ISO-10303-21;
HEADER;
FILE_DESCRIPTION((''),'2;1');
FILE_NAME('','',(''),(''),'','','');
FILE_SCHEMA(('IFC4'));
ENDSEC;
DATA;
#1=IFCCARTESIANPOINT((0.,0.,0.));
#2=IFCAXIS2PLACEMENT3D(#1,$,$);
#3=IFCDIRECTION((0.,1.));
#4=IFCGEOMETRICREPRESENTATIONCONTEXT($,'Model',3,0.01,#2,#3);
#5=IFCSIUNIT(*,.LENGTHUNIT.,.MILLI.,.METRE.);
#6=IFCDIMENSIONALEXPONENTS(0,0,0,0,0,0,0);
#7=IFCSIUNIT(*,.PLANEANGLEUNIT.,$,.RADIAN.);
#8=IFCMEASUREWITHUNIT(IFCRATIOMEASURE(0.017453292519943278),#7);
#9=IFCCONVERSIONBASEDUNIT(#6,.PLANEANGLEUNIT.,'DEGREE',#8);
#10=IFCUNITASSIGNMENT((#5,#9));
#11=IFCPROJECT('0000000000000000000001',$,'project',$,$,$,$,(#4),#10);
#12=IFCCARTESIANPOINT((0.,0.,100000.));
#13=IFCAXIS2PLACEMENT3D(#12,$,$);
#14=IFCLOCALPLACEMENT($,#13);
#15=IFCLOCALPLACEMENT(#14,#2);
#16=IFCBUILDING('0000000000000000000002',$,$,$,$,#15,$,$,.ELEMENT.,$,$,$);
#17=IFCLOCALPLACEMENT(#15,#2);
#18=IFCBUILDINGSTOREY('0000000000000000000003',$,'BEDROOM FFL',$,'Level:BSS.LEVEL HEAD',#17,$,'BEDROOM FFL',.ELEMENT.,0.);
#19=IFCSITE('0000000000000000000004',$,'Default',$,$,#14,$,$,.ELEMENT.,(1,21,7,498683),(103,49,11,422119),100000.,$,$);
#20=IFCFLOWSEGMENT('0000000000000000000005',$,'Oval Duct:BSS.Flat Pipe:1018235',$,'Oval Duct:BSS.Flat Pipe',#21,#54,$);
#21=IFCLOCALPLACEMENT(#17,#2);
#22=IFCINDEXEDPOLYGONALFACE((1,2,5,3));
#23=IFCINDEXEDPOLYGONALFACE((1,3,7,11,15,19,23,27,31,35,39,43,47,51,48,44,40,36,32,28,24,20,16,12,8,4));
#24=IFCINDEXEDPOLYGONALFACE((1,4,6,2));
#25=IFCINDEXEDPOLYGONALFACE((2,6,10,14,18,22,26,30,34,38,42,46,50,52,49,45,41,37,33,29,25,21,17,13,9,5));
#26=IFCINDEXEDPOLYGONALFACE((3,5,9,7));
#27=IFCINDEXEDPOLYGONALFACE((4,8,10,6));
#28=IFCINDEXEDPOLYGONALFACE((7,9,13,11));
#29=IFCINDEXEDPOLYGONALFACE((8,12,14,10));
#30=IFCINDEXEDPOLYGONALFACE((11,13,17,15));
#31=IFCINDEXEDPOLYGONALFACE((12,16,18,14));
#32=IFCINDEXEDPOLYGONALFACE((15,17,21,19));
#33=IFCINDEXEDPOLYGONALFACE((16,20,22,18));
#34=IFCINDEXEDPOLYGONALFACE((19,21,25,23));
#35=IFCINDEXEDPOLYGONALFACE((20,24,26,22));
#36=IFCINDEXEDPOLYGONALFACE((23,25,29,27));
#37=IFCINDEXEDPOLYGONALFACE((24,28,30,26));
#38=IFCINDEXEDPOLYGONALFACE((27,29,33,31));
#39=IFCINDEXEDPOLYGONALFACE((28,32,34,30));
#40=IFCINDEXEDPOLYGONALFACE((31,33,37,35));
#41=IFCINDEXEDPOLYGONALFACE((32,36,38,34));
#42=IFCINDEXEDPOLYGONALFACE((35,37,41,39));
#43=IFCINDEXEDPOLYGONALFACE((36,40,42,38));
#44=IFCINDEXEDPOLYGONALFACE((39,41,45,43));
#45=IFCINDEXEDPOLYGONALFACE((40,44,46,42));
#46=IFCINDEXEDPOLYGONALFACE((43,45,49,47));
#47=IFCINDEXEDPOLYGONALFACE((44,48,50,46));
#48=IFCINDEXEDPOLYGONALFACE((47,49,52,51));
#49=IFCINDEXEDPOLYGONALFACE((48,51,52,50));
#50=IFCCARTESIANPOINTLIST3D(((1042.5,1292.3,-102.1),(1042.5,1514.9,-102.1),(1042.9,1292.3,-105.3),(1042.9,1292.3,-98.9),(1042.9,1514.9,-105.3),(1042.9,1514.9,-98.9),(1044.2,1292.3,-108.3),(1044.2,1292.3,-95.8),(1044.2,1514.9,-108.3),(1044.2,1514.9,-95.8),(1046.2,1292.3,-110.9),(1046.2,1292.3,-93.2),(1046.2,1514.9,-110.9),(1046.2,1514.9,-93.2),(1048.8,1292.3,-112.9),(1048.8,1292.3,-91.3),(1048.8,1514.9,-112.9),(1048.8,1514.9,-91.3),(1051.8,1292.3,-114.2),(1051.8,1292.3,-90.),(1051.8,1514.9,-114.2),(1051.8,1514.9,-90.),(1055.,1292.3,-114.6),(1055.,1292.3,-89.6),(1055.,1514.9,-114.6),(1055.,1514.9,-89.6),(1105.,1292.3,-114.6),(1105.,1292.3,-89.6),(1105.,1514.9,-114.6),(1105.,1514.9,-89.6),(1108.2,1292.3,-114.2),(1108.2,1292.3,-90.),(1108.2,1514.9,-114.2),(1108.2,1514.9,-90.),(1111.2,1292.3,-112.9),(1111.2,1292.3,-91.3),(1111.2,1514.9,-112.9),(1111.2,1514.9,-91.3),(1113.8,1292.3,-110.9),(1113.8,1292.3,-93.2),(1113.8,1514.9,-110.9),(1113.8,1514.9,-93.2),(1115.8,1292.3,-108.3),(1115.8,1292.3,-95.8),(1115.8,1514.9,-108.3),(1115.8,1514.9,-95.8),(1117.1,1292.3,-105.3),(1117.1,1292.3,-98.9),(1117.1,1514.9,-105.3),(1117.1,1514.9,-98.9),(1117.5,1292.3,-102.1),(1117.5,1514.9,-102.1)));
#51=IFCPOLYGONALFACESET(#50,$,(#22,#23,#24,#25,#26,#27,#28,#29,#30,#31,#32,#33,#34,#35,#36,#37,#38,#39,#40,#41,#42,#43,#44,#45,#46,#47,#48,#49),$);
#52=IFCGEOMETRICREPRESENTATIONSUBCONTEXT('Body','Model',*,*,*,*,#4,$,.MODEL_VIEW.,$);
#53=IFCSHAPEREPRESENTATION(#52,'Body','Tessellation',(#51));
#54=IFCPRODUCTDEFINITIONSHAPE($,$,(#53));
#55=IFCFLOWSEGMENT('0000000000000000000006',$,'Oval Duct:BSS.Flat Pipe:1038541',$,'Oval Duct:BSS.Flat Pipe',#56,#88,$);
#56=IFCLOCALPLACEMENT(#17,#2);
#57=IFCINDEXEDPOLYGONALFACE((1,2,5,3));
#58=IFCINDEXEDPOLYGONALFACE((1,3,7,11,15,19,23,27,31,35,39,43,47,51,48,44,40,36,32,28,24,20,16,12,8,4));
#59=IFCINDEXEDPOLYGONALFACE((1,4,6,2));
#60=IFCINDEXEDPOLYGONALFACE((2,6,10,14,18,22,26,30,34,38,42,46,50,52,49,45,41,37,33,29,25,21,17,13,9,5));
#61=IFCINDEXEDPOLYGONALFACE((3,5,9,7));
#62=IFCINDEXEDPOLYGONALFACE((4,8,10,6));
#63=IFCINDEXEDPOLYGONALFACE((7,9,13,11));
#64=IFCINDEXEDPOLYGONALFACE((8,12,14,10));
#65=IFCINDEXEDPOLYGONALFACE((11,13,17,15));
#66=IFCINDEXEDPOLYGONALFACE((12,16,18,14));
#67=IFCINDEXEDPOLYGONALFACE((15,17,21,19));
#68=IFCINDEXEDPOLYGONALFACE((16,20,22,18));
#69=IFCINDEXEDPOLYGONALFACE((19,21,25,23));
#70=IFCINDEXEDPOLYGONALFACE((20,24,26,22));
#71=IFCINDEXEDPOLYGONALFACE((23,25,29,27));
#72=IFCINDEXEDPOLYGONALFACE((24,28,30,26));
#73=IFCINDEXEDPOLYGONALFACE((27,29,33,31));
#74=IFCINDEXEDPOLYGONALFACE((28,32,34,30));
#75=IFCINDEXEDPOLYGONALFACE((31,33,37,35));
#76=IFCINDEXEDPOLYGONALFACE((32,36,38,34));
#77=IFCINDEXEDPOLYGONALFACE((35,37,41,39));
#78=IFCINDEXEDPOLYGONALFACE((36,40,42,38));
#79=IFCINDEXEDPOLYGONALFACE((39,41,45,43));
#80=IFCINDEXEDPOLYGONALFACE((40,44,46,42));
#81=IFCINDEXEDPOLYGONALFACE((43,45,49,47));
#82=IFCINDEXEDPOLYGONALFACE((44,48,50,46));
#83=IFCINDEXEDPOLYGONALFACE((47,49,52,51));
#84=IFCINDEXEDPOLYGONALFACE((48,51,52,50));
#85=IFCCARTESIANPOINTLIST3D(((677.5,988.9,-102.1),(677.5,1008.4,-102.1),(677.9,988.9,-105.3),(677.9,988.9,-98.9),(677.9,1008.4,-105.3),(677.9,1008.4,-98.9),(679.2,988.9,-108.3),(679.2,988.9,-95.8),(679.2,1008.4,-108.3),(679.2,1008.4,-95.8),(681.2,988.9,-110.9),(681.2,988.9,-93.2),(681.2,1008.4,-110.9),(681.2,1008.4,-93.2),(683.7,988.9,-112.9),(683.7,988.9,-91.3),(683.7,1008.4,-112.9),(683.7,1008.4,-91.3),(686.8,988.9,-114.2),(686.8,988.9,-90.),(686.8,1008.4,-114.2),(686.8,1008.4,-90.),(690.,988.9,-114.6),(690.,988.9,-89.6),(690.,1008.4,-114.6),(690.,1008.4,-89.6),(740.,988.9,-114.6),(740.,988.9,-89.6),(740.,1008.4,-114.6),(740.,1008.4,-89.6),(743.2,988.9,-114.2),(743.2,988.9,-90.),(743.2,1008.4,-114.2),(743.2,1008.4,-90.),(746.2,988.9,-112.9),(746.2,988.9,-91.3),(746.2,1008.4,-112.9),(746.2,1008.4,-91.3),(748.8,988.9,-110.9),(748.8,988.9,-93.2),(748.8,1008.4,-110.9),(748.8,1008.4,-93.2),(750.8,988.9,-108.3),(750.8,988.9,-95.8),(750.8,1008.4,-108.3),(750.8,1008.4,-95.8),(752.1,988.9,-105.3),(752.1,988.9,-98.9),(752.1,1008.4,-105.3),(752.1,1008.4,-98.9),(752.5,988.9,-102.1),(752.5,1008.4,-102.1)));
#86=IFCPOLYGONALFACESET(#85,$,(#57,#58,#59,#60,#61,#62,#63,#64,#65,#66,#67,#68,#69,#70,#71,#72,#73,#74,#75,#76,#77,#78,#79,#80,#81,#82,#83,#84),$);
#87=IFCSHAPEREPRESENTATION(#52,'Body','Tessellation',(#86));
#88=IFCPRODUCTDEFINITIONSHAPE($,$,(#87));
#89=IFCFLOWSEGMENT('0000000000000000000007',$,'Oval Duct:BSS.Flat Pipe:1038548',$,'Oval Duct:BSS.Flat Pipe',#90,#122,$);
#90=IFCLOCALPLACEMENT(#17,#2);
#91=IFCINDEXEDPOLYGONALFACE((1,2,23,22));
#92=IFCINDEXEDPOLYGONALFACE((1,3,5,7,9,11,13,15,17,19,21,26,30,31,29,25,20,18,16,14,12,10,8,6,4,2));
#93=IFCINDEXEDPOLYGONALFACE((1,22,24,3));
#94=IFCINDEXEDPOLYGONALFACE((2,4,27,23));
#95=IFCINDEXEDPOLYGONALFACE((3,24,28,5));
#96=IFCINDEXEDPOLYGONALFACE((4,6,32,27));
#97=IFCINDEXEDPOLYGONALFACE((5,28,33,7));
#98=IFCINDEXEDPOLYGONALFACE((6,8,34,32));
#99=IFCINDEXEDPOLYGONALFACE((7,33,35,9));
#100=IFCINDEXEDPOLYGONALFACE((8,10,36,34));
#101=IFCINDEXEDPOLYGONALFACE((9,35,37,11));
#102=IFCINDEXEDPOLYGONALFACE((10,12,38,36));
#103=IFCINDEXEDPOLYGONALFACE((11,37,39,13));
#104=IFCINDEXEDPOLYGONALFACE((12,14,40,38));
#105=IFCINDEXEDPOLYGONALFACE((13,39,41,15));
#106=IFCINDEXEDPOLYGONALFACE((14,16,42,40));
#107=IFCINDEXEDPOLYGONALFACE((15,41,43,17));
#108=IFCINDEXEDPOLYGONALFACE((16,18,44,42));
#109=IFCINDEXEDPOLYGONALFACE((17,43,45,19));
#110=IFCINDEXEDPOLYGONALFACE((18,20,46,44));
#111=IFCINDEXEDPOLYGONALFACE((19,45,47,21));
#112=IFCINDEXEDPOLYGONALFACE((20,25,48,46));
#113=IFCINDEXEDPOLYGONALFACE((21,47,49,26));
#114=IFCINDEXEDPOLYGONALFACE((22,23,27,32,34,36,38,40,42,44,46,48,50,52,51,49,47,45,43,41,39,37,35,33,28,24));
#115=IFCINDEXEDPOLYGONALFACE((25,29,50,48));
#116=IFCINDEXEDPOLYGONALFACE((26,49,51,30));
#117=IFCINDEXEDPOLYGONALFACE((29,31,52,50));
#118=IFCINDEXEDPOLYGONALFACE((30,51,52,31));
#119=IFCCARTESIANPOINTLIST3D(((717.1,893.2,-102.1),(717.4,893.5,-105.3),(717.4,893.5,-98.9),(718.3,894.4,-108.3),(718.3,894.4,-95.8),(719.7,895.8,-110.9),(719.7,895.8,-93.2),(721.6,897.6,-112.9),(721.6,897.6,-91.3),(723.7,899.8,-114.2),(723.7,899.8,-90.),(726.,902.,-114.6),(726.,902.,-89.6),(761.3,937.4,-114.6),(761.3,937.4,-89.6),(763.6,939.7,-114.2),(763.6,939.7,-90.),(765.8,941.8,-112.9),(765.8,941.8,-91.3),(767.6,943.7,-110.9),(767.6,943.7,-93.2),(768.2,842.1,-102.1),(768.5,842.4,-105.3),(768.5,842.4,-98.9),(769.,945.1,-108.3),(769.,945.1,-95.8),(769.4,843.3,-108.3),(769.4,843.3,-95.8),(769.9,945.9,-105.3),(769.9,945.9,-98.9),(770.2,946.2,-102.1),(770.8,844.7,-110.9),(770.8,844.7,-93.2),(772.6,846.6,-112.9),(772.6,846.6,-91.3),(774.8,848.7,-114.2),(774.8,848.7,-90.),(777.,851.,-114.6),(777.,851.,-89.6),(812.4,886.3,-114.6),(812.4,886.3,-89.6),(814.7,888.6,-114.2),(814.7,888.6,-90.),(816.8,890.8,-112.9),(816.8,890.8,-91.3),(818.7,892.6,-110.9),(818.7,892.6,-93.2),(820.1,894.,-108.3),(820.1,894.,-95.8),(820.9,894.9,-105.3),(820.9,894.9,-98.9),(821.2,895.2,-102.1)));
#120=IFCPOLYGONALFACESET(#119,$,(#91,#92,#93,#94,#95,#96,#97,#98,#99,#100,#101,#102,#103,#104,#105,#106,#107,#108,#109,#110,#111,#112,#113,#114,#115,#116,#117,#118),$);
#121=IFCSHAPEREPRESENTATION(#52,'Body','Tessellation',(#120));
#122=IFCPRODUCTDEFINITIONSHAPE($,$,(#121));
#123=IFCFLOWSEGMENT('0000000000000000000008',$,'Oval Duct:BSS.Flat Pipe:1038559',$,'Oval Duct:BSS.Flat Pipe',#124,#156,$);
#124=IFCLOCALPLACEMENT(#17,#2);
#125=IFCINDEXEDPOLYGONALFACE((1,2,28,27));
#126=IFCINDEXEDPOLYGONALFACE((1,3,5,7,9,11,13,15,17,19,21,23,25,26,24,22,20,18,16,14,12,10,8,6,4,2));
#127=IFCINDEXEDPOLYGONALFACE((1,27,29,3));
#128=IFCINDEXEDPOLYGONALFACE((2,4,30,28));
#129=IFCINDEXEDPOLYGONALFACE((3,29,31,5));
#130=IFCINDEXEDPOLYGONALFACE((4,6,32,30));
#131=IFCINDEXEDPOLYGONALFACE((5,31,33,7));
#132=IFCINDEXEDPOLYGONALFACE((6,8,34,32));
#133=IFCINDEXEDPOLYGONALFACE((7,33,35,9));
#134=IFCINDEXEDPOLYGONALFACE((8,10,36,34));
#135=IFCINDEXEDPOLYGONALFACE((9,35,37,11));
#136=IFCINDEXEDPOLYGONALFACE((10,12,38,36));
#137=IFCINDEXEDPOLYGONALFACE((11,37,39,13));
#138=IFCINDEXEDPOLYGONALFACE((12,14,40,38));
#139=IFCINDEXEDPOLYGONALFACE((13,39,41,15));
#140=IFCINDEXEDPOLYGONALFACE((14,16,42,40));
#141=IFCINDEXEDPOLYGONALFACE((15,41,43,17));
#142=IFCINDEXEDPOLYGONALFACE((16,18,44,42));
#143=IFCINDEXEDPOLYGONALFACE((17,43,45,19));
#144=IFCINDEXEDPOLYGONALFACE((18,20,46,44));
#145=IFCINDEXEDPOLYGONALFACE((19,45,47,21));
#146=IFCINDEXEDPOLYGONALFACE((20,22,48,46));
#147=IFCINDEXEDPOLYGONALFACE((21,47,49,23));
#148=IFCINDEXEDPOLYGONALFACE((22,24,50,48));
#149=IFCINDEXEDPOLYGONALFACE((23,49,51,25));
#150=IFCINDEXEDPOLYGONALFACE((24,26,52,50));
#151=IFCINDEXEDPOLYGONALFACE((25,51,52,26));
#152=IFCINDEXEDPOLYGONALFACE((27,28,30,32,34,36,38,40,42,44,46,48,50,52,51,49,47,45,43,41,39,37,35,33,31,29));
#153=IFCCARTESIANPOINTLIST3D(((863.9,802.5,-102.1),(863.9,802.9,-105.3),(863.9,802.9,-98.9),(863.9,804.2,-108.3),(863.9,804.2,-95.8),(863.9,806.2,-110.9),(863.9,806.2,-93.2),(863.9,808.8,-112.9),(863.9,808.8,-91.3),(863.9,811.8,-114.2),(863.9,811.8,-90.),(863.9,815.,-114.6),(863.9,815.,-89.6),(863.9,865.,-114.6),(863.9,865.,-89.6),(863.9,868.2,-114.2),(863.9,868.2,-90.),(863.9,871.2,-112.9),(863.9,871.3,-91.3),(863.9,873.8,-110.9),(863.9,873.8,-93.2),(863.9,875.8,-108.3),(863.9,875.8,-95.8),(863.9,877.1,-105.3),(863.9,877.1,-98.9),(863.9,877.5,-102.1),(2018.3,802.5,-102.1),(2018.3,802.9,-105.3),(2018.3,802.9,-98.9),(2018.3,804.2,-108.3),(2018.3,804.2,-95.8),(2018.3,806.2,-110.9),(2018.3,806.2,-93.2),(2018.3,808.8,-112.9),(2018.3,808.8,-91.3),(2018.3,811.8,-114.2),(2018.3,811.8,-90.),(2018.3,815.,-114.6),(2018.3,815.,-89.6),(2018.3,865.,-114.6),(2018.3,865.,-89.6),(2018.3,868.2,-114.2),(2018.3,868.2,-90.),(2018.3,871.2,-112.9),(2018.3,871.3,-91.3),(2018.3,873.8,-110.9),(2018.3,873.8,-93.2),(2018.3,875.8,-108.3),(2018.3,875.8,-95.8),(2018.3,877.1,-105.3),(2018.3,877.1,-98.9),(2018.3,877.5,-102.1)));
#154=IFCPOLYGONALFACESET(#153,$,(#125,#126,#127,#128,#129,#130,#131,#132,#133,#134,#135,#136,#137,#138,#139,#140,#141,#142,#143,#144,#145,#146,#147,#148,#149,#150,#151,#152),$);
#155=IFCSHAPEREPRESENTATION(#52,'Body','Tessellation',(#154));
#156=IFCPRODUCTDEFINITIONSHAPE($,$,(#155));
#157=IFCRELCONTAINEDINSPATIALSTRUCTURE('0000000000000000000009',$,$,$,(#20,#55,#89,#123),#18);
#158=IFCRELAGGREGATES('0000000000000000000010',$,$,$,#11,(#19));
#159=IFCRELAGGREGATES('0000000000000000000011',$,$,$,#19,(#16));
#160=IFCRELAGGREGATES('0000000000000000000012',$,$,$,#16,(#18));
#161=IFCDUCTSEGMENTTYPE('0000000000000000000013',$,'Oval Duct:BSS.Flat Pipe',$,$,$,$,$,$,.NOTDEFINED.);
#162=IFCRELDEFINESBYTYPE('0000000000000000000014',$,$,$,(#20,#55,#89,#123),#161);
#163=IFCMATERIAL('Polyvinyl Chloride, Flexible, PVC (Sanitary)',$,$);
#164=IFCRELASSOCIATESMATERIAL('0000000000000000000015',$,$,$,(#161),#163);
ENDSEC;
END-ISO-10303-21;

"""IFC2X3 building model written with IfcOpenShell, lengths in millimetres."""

from ifc_helpers import new_model, entity, si_unit, converted_unit, direction, frame, frame_2d, origin, place, context, subcontext, project, spatial, polyline, circle_curve, parameter, trimmed, segment, composite_curve, outline, extrude, material, type_object, element, save


model = new_model("IFC2X3")

# Units and contexts
model_context = context("Model", 3, precision=0.01, world=origin(), true_north=direction((0.0, 1.0)))
body_context = subcontext(model_context, "Body", "Model", "MODEL_VIEW")
ifc_project = project(units=[si_unit("LENGTHUNIT", "METRE", prefix="MILLI"), converted_unit("PLANEANGLEUNIT", "DEGREE", entity("IfcRatioMeasure", 0.017453292519943278), si_unit("PLANEANGLEUNIT", "RADIAN"), dimensions=[0, 0, 0, 0, 0, 0, 0])], contexts=[model_context])

# Site, building, storey
site_placement = place(None, frame((0.0, 0.0, 100000.0)))
site = spatial("IfcSite", under=ifc_project, at=site_placement, Name="Default", CompositionType="ELEMENT", RefLatitude=(1, 21, 7, 498683), RefLongitude=(103, 49, 11, 422119), RefElevation=100000.0)
building_placement = place(site_placement, origin())
building = spatial("IfcBuilding", under=site, at=building_placement, CompositionType="ELEMENT")
storey_placement = place(building_placement, origin())
storey = spatial("IfcBuildingStorey", under=building, at=storey_placement, Name="BEDROOM FFL", ObjectType="Level:BSS.LEVEL HEAD", LongName="BEDROOM FFL", CompositionType="ELEMENT", Elevation=0.0)

# Flow segments
ifc_material_1 = material(Name="Polyvinyl Chloride, Flexible, PVC (Sanitary)")
duct_segment_type = type_object("IfcDuctSegmentType", Name="Oval Duct:BSS.Flat Pipe", PredefinedType="NOTDEFINED", material=ifc_material_1)
flow_segment_1_placement = place(storey_placement, origin())
element("IfcFlowSegment", 1, at=flow_segment_1_placement, inside=storey, type_object=duct_segment_type, Name="Oval Duct:BSS.Flat Pipe:1018235", ObjectType="Oval Duct:BSS.Flat Pipe", context=body_context, shape_type="SweptSolid", body=[
    extrude(outline(composite_curve([segment(trimmed(circle_curve(frame_2d((25.0, 0.0), x_axis=(1.0, 0.0)), 12.5), [parameter(270.0)], [parameter(0.0)], True, "PARAMETER"), True, "CONTINUOUS"), segment(trimmed(circle_curve(frame_2d((25.0, 0.0), x_axis=(1.0, 0.0)), 12.5), [parameter(0.0)], [parameter(90.0)], True, "PARAMETER"), True, "CONTINUOUS"), segment(polyline([(25.0, 12.5), (-25.0, 12.5)]), True, "CONTINUOUS"), segment(trimmed(circle_curve(frame_2d((-25.0, 0.0), x_axis=(1.0, 0.0)), 12.5), [parameter(90.0)], [parameter(180.0)], True, "PARAMETER"), True, "CONTINUOUS"), segment(trimmed(circle_curve(frame_2d((-25.0, 0.0), x_axis=(1.0, 0.0)), 12.5), [parameter(180.0)], [parameter(270.0)], True, "PARAMETER"), True, "CONTINUOUS"), segment(polyline([(-25.0, -12.5), (25.0, -12.5)]), True, "CONTINUOUS")], self_intersect=False)), frame((1080.0, 1292.3, -102.1), z_axis=(0.0, 1.0, 0.0), x_axis=(1.0, 0.0, 0.0)), (0.0, 0.0, 1.0), 222.6),
])
flow_segment_2_placement = place(storey_placement, origin())
element("IfcFlowSegment", 2, at=flow_segment_2_placement, inside=storey, type_object=duct_segment_type, Name="Oval Duct:BSS.Flat Pipe:1038541", ObjectType="Oval Duct:BSS.Flat Pipe", context=body_context, shape_type="SweptSolid", body=[
    extrude(outline(composite_curve([segment(polyline([(-25.0, -12.5), (25.0, -12.5)]), True, "CONTINUOUS"), segment(trimmed(circle_curve(frame_2d((25.0, 0.0), x_axis=(-1.0, 0.0)), 12.5), [parameter(90.0)], [parameter(180.0)], True, "PARAMETER"), True, "CONTINUOUS"), segment(trimmed(circle_curve(frame_2d((25.0, 0.0), x_axis=(-1.0, 0.0)), 12.5), [parameter(180.0)], [parameter(270.0)], True, "PARAMETER"), True, "CONTINUOUS"), segment(polyline([(25.0, 12.5), (-25.0, 12.5)]), True, "CONTINUOUS"), segment(trimmed(circle_curve(frame_2d((-25.0, 0.0), x_axis=(-1.0, 0.0)), 12.5), [parameter(270.0)], [parameter(0.0)], True, "PARAMETER"), True, "CONTINUOUS"), segment(trimmed(circle_curve(frame_2d((-25.0, 0.0), x_axis=(-1.0, 0.0)), 12.5), [parameter(0.0)], [parameter(90.0)], True, "PARAMETER"), True, "CONTINUOUS")], self_intersect=False)), frame((715.0, 988.9, -102.1), z_axis=(0.0, 1.0, 0.0), x_axis=(1.0, 0.0, 0.0)), (0.0, 0.0, 1.0), 19.5),
])
flow_segment_3_placement = place(storey_placement, origin())
element("IfcFlowSegment", 3, at=flow_segment_3_placement, inside=storey, type_object=duct_segment_type, Name="Oval Duct:BSS.Flat Pipe:1038548", ObjectType="Oval Duct:BSS.Flat Pipe", context=body_context, shape_type="SweptSolid", body=[
    extrude(outline(composite_curve([segment(polyline([(-25.0, -12.5), (25.0, -12.5)]), True, "CONTINUOUS"), segment(trimmed(circle_curve(frame_2d((25.0, 0.0), x_axis=(-1.0, 0.0)), 12.5), [parameter(90.0)], [parameter(180.0)], True, "PARAMETER"), True, "CONTINUOUS"), segment(trimmed(circle_curve(frame_2d((25.0, 0.0), x_axis=(-1.0, 0.0)), 12.5), [parameter(180.0)], [parameter(270.0)], True, "PARAMETER"), True, "CONTINUOUS"), segment(polyline([(25.0, 12.5), (-25.0, 12.5)]), True, "CONTINUOUS"), segment(trimmed(circle_curve(frame_2d((-25.0, 0.0), x_axis=(-1.0, 0.0)), 12.5), [parameter(270.0)], [parameter(0.0)], True, "PARAMETER"), True, "CONTINUOUS"), segment(trimmed(circle_curve(frame_2d((-25.0, 0.0), x_axis=(-1.0, 0.0)), 12.5), [parameter(0.0)], [parameter(90.0)], True, "PARAMETER"), True, "CONTINUOUS")], self_intersect=False)), frame((794.7, 868.7, -102.1), z_axis=(-0.707107, 0.707107, 0.0), x_axis=(0.707107, 0.707107, 0.0)), (0.0, 0.0, 1.0), 72.2),
])
flow_segment_4_placement = place(storey_placement, origin())
element("IfcFlowSegment", 4, at=flow_segment_4_placement, inside=storey, type_object=duct_segment_type, Name="Oval Duct:BSS.Flat Pipe:1038559", ObjectType="Oval Duct:BSS.Flat Pipe", context=body_context, shape_type="SweptSolid", body=[
    extrude(outline(composite_curve([segment(trimmed(circle_curve(frame_2d((25.0, 0.0), x_axis=(1.0, 0.0)), 12.5), [parameter(270.0)], [parameter(0.0)], True, "PARAMETER"), True, "CONTINUOUS"), segment(trimmed(circle_curve(frame_2d((25.0, 0.0), x_axis=(1.0, 0.0)), 12.5), [parameter(0.0)], [parameter(90.0)], True, "PARAMETER"), True, "CONTINUOUS"), segment(polyline([(25.0, 12.5), (-25.0, 12.5)]), True, "CONTINUOUS"), segment(trimmed(circle_curve(frame_2d((-25.0, 0.0), x_axis=(1.0, 0.0)), 12.5), [parameter(90.0)], [parameter(180.0)], True, "PARAMETER"), True, "CONTINUOUS"), segment(trimmed(circle_curve(frame_2d((-25.0, 0.0), x_axis=(1.0, 0.0)), 12.5), [parameter(180.0)], [parameter(270.0)], True, "PARAMETER"), True, "CONTINUOUS"), segment(polyline([(-25.0, -12.5), (25.0, -12.5)]), True, "CONTINUOUS")], self_intersect=False)), frame((863.9, 840.0, -102.1), z_axis=(1.0, 0.0, 0.0), x_axis=(0.0, -1.0, 0.0)), (0.0, 0.0, 1.0), 1154.4),
])

save(model, "model.ifc")
